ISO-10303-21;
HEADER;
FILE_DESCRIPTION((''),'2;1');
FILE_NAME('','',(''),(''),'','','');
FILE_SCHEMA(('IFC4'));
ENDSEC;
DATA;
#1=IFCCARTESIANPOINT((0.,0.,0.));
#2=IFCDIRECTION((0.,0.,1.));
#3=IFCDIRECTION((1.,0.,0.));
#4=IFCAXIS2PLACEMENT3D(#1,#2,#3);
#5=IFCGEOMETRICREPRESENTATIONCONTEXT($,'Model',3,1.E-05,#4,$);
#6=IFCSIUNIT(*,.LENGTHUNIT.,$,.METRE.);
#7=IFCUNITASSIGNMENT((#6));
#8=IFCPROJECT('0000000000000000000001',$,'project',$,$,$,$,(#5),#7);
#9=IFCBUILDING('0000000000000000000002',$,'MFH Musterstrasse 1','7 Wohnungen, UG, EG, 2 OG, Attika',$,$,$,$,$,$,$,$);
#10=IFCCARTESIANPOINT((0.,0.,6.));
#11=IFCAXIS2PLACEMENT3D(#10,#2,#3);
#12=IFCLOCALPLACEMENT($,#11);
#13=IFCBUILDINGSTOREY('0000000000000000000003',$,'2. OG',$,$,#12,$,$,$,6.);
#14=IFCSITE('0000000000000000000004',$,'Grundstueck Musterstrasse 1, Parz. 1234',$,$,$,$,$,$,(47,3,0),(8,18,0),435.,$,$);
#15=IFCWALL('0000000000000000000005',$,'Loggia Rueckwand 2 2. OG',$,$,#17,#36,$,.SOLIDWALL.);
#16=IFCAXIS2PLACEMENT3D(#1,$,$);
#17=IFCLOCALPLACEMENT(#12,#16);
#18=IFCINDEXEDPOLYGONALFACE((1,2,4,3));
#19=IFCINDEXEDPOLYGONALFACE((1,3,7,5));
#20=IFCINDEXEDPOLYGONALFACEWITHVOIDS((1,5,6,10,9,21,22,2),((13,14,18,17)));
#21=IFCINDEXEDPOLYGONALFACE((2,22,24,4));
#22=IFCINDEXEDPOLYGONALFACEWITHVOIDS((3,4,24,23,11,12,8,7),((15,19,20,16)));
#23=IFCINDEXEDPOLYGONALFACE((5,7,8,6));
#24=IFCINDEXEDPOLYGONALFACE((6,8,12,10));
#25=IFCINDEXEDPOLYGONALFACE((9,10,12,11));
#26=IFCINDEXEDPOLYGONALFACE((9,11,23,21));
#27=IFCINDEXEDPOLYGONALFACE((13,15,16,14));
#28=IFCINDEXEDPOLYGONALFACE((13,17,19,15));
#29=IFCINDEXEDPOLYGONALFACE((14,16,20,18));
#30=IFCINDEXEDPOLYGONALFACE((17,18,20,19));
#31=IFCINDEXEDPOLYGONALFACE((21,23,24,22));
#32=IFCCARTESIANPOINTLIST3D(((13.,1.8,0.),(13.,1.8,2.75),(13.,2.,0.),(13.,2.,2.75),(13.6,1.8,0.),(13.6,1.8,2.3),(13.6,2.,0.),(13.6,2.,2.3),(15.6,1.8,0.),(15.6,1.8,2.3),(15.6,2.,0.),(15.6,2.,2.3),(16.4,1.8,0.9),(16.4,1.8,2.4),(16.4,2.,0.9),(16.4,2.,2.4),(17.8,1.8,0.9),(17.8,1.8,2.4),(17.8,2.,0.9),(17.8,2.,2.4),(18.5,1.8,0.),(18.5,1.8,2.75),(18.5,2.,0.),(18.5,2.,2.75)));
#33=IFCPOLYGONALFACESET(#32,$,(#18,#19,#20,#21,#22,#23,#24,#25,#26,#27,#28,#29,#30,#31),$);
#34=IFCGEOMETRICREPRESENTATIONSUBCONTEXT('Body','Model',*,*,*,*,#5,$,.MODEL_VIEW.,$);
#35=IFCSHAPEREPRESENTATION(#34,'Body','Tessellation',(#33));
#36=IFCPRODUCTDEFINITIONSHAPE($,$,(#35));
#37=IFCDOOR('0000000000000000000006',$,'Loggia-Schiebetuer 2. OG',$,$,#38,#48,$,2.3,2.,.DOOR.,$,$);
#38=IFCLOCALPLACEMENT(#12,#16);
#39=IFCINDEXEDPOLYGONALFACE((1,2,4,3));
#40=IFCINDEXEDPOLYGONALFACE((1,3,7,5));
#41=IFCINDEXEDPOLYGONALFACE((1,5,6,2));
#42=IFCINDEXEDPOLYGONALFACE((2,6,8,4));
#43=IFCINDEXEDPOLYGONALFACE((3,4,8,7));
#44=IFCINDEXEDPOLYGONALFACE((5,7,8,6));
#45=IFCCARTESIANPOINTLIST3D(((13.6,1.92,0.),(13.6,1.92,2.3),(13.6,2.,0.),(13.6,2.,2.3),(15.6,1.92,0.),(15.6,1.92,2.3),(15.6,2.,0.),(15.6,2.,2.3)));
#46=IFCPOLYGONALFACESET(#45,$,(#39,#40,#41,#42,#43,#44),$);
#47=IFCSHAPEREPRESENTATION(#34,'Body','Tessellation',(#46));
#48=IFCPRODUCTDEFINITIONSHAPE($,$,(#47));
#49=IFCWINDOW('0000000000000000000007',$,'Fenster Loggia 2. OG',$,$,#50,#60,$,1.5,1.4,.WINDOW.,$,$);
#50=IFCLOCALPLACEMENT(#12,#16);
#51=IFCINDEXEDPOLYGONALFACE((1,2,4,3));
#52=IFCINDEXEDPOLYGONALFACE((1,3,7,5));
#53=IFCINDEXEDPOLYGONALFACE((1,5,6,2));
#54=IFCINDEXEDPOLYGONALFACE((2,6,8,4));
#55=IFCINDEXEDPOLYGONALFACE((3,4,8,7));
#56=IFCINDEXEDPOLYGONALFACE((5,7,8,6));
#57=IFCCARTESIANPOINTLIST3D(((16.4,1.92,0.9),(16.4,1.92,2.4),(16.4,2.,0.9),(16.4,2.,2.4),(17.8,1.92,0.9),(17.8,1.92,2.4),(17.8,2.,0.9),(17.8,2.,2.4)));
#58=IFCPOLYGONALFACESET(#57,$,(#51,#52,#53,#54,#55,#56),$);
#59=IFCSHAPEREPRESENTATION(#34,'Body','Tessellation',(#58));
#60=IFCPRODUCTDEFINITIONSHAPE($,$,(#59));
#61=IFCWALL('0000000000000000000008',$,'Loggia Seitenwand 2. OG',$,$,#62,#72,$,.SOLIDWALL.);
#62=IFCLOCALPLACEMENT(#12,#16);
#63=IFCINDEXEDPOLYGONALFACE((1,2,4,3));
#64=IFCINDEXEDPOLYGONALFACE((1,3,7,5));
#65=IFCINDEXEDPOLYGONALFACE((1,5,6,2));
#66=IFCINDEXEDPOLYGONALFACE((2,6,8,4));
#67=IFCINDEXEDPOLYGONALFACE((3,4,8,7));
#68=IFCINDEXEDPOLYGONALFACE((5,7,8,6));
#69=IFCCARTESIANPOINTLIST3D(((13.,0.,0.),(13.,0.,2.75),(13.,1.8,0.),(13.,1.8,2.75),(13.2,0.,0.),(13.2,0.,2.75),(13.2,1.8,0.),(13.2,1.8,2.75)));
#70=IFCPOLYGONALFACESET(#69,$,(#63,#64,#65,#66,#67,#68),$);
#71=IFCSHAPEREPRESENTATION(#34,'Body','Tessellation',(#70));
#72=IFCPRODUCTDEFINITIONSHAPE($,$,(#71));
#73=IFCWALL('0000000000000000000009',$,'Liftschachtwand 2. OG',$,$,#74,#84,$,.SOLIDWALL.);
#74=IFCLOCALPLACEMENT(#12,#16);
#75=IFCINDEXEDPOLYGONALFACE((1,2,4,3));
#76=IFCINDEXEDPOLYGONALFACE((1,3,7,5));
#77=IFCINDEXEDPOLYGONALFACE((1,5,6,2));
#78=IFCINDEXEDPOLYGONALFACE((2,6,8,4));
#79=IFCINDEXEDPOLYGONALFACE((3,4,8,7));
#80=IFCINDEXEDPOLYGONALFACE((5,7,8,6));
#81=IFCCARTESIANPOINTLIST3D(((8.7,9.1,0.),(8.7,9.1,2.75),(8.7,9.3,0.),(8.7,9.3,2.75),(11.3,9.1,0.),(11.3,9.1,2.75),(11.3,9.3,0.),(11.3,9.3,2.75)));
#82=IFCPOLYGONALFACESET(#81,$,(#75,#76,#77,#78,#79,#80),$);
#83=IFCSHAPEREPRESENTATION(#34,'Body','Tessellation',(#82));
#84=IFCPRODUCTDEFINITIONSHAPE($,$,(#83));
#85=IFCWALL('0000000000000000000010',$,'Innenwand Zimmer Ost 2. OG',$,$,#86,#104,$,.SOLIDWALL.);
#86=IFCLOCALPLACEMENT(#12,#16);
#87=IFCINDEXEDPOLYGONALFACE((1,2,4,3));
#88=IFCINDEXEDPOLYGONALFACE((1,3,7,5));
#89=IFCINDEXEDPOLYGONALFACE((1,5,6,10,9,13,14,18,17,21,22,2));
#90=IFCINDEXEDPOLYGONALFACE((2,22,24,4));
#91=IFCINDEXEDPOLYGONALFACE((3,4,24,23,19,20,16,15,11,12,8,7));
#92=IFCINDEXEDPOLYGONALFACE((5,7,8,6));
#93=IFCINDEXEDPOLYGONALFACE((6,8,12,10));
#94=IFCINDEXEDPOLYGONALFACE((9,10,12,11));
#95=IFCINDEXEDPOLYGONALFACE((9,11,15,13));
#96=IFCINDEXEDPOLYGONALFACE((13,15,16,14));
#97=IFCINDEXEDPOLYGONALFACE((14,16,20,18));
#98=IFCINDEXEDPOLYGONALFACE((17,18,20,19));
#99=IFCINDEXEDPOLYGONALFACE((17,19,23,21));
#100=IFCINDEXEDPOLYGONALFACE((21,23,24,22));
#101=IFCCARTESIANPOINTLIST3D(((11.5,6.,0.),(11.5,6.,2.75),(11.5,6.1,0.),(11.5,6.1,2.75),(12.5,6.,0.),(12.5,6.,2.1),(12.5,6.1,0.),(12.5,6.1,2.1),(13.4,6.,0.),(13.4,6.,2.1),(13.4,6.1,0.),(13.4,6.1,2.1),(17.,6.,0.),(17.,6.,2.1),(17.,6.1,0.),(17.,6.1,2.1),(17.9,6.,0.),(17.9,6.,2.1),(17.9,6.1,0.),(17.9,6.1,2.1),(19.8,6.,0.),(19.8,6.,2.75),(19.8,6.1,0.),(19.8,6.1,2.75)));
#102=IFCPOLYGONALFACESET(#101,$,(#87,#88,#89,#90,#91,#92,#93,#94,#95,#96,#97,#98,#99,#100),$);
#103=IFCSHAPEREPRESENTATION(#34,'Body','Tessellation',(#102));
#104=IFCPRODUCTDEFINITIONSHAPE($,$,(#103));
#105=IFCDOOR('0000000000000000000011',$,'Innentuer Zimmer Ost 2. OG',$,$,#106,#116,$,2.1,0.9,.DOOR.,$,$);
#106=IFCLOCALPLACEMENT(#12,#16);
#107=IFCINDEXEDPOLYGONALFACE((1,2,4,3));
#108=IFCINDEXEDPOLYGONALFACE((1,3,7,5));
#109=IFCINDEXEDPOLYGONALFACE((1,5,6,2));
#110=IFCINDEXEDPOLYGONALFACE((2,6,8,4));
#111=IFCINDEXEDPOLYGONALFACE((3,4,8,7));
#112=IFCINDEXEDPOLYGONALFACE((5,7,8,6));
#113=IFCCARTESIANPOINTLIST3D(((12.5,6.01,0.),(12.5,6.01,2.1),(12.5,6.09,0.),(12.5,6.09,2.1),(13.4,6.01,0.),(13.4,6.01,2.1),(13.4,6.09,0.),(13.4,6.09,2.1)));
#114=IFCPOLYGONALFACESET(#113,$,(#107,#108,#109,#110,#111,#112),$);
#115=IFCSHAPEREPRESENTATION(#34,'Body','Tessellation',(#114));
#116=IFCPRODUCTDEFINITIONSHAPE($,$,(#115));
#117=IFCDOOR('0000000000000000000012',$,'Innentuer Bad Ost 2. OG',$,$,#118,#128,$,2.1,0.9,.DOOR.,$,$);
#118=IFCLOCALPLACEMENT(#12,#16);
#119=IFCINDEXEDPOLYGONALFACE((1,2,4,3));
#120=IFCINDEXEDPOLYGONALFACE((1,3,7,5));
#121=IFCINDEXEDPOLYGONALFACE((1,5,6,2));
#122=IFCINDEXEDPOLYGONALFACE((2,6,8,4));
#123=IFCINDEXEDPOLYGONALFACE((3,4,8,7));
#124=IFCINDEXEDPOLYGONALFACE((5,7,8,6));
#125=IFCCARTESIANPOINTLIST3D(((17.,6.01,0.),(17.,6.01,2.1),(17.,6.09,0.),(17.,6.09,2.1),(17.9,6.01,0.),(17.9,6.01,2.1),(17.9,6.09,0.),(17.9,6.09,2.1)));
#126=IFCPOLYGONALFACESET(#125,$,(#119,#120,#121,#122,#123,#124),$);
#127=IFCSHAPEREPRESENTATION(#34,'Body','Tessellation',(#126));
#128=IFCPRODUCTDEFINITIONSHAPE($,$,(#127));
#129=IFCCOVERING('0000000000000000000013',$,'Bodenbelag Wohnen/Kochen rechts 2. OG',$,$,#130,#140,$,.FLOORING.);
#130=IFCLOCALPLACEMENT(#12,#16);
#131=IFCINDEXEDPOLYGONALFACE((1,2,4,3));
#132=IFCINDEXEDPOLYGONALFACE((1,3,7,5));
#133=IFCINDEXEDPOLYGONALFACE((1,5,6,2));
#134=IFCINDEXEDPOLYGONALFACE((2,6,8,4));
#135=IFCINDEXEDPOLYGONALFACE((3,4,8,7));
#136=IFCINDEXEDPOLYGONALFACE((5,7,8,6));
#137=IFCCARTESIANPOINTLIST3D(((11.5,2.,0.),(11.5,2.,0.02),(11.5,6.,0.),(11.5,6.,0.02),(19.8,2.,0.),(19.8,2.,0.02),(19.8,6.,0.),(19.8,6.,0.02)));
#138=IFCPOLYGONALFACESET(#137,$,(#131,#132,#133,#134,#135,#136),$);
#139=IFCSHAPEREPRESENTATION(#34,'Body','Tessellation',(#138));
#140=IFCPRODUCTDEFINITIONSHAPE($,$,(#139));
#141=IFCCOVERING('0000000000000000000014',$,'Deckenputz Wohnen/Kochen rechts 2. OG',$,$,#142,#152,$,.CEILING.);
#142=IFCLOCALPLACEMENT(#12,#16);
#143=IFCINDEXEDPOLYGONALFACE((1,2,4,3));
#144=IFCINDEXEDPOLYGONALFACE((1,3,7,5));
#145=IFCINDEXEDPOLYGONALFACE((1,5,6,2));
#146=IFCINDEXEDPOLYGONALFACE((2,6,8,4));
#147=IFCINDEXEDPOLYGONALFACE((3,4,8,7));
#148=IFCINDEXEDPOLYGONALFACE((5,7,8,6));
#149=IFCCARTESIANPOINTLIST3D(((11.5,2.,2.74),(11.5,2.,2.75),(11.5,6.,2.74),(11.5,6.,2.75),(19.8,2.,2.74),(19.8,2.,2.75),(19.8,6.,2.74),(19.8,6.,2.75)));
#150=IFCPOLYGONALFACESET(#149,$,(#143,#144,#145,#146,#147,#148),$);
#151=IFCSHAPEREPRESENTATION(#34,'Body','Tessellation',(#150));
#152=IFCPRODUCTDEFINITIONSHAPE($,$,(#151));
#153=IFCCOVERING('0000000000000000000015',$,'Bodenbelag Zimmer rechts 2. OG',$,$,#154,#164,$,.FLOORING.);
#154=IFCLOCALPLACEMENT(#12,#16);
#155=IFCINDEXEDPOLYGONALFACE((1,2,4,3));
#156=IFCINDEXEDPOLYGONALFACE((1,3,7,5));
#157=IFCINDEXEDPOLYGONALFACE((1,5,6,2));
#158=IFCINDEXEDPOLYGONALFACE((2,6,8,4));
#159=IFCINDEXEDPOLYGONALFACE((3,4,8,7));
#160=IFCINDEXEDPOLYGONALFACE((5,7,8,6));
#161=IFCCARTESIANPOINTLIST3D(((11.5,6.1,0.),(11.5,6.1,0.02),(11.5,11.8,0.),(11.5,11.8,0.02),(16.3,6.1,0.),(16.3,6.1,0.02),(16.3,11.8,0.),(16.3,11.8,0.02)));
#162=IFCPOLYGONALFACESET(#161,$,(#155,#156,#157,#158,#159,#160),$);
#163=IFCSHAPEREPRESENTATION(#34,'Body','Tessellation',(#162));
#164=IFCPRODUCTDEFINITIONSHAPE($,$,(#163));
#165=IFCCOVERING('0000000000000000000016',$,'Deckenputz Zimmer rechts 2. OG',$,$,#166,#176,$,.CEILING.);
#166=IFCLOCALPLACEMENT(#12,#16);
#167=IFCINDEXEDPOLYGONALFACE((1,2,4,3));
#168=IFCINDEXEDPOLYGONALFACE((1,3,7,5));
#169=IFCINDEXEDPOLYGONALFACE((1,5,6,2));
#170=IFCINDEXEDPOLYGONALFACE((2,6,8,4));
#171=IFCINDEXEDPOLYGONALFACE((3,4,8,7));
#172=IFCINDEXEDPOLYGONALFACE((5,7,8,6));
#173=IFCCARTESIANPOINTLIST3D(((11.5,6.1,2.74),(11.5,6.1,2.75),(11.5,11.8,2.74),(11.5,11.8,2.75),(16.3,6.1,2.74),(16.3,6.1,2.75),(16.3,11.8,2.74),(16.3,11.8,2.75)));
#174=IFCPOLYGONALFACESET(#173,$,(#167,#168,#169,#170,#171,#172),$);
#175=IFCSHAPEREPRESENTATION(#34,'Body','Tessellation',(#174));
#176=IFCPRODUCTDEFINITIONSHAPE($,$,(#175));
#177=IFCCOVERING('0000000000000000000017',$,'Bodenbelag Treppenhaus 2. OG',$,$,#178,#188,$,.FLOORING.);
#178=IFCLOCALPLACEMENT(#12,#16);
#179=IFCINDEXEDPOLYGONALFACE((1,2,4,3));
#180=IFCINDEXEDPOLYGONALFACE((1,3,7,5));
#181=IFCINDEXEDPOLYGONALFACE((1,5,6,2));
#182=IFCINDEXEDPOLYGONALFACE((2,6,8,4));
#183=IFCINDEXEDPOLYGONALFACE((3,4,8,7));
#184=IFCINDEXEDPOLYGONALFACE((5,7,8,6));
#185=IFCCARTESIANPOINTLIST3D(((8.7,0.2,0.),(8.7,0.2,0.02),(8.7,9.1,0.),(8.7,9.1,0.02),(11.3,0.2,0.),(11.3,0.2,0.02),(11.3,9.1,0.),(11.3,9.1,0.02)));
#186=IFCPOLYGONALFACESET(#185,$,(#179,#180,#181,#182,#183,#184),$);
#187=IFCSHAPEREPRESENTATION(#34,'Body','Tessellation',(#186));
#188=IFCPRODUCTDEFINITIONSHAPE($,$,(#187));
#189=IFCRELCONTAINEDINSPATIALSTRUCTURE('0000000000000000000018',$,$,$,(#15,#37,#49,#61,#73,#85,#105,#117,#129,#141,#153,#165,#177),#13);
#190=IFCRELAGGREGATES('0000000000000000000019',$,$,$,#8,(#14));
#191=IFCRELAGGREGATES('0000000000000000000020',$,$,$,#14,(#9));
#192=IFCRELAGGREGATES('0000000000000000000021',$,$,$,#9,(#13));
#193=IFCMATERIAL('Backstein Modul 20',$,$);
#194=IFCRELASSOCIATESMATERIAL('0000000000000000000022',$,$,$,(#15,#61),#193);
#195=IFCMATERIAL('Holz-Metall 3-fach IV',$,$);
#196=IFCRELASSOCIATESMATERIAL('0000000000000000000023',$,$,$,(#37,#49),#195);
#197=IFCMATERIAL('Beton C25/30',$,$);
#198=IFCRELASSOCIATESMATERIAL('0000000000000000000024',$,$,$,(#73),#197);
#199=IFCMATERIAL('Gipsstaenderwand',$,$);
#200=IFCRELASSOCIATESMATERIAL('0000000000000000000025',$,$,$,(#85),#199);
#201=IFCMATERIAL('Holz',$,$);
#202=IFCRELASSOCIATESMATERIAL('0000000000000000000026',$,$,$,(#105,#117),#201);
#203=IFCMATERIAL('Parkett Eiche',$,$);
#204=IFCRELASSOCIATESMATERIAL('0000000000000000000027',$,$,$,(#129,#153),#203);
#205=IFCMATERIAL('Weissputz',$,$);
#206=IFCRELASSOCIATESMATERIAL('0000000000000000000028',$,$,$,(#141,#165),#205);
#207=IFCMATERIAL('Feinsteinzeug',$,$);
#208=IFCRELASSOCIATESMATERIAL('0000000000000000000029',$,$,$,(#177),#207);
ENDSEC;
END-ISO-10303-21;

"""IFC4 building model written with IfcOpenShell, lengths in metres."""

from ifc_helpers import new_model, si_unit, frame, frame_2d, origin_with_axes, place, context, subcontext, project, spatial, rectangle, extrude, material, element, fill, save


model = new_model("IFC4")

# Units and contexts
model_context = context("Model", 3, precision=1e-05, world=origin_with_axes())
body_context = subcontext(model_context, "Body", "Model", "MODEL_VIEW")
ifc_project = project(units=[si_unit("LENGTHUNIT", "METRE")], contexts=[model_context])

# Site, building, storey
site = spatial("IfcSite", under=ifc_project, Name="Grundstueck Musterstrasse 1, Parz. 1234", RefLatitude=(47, 3, 0), RefLongitude=(8, 18, 0), RefElevation=435.0)
building = spatial("IfcBuilding", under=site, Name="MFH Musterstrasse 1", Description="7 Wohnungen, UG, EG, 2 OG, Attika")
storey_placement = place(None, frame((0.0, 0.0, 6.0), z_axis=(0.0, 0.0, 1.0), x_axis=(1.0, 0.0, 0.0)))
storey = spatial("IfcBuildingStorey", under=building, at=storey_placement, Name="2. OG", Elevation=6.0)

# Wall, openings, door, window
ifc_material_1 = material(Name="Backstein Modul 20")
wall_1_placement = place(storey_placement, frame((13.0, 1.8, 0.0), z_axis=(0.0, 0.0, 1.0), x_axis=(1.0, 0.0, 0.0)))
wall_1 = element("IfcWall", 1, at=wall_1_placement, inside=storey, material=ifc_material_1, Name="Loggia Rueckwand 2 2. OG", PredefinedType="SOLIDWALL", context=body_context, shape_type="SweptSolid", body=[
    extrude(rectangle(XDim=5.5, YDim=0.2, at=frame_2d((2.75, 0.1))), origin_with_axes(), (0.0, 0.0, 1.0), 2.75),
])
opening_1_placement = place(wall_1_placement, frame((0.6, -0.21, 0.0), z_axis=(0.0, 0.0, 1.0), x_axis=(1.0, 0.0, 0.0)))
opening_1 = element("IfcOpeningElement", 2, at=opening_1_placement, cuts=wall_1, context=body_context, shape_type="SweptSolid", body=[
    extrude(rectangle(XDim=2.0, YDim=0.42, at=frame_2d((1.0, 0.21))), origin_with_axes(), (0.0, 0.0, 1.0), 2.3),
])
opening_2_placement = place(wall_1_placement, frame((3.4, -0.21, 0.9), z_axis=(0.0, 0.0, 1.0), x_axis=(1.0, 0.0, 0.0)))
opening_2 = element("IfcOpeningElement", 3, at=opening_2_placement, cuts=wall_1, context=body_context, shape_type="SweptSolid", body=[
    extrude(rectangle(XDim=1.4, YDim=0.42, at=frame_2d((0.7, 0.21))), origin_with_axes(), (0.0, 0.0, 1.0), 1.5),
])
ifc_material_2 = material(Name="Holz-Metall 3-fach IV")
door_1_placement = place(storey_placement, frame((13.6, 1.92, 0.0), z_axis=(0.0, 0.0, 1.0), x_axis=(1.0, 0.0, 0.0)))
door_1 = element("IfcDoor", 4, at=door_1_placement, inside=storey, material=ifc_material_2, Name="Loggia-Schiebetuer 2. OG", OverallHeight=2.3, OverallWidth=2.0, PredefinedType="DOOR", context=body_context, shape_type="SweptSolid", body=[
    extrude(rectangle(XDim=2.0, YDim=0.08, at=frame_2d((1.0, 0.04))), origin_with_axes(), (0.0, 0.0, 1.0), 2.3),
])
fill(opening_1, door_1)
window_placement = place(storey_placement, frame((16.4, 1.92, 0.9), z_axis=(0.0, 0.0, 1.0), x_axis=(1.0, 0.0, 0.0)))
window = element("IfcWindow", 5, at=window_placement, inside=storey, material=ifc_material_2, Name="Fenster Loggia 2. OG", OverallHeight=1.5, OverallWidth=1.4, PredefinedType="WINDOW", context=body_context, shape_type="SweptSolid", body=[
    extrude(rectangle(XDim=1.4, YDim=0.08, at=frame_2d((0.7, 0.04))), origin_with_axes(), (0.0, 0.0, 1.0), 1.5),
])
fill(opening_2, window)

# Wall
wall_2_placement = place(storey_placement, frame((13.0, 0.2, 0.0), z_axis=(0.0, 0.0, 1.0), x_axis=(1.0, 0.0, 0.0)))
element("IfcWall", 6, at=wall_2_placement, inside=storey, material=ifc_material_1, Name="Loggia Seitenwand 2. OG", PredefinedType="SOLIDWALL", context=body_context, shape_type="SweptSolid", body=[
    extrude(rectangle(XDim=0.2, YDim=1.8, at=frame_2d((0.1, 0.7))), origin_with_axes(), (0.0, 0.0, 1.0), 2.75),
])

# Shared definitions
ifc_material_3 = material(Name="Beton C25/30")
ifc_material_4 = material(Name="Holz")

# Wall
wall_3_placement = place(storey_placement, frame((8.7, 9.1, 0.0), z_axis=(0.0, 0.0, 1.0), x_axis=(1.0, 0.0, 0.0)))
element("IfcWall", 7, at=wall_3_placement, inside=storey, material=ifc_material_3, Name="Liftschachtwand 2. OG", PredefinedType="SOLIDWALL", context=body_context, shape_type="SweptSolid", body=[
    extrude(rectangle(XDim=2.6, YDim=0.2, at=frame_2d((1.3, 0.1))), origin_with_axes(), (0.0, 0.0, 1.0), 2.75),
])

# Wall, openings, doors
ifc_material_5 = material(Name="Gipsstaenderwand")
wall_4_placement = place(storey_placement, frame((11.5, 6.0, 0.0), z_axis=(0.0, 0.0, 1.0), x_axis=(1.0, 0.0, 0.0)))
wall_4 = element("IfcWall", 8, at=wall_4_placement, inside=storey, material=ifc_material_5, Name="Innenwand Zimmer Ost 2. OG", PredefinedType="SOLIDWALL", context=body_context, shape_type="SweptSolid", body=[
    extrude(rectangle(XDim=8.3, YDim=0.1, at=frame_2d((4.15, 0.05))), origin_with_axes(), (0.0, 0.0, 1.0), 2.75),
])
opening_3_placement = place(wall_4_placement, frame((1.0, -0.01, 0.0), z_axis=(0.0, 0.0, 1.0), x_axis=(1.0, 0.0, 0.0)))
opening_3 = element("IfcOpeningElement", 9, at=opening_3_placement, cuts=wall_4, context=body_context, shape_type="SweptSolid", body=[
    extrude(rectangle(XDim=0.9, YDim=0.12, at=frame_2d((0.45, 0.06))), origin_with_axes(), (0.0, 0.0, 1.0), 2.1),
])
opening_4_placement = place(wall_4_placement, frame((5.5, -0.01, 0.0), z_axis=(0.0, 0.0, 1.0), x_axis=(1.0, 0.0, 0.0)))
opening_4 = element("IfcOpeningElement", 10, at=opening_4_placement, cuts=wall_4, context=body_context, shape_type="SweptSolid", body=[
    extrude(rectangle(XDim=0.9, YDim=0.12, at=frame_2d((0.45, 0.06))), origin_with_axes(), (0.0, 0.0, 1.0), 2.1),
])
door_2_placement = place(storey_placement, frame((12.5, 6.01, 0.0), z_axis=(0.0, 0.0, 1.0), x_axis=(1.0, 0.0, 0.0)))
door_2 = element("IfcDoor", 11, at=door_2_placement, inside=storey, material=ifc_material_4, Name="Innentuer Zimmer Ost 2. OG", OverallHeight=2.1, OverallWidth=0.9, PredefinedType="DOOR", context=body_context, shape_type="SweptSolid", body=[
    extrude(rectangle(XDim=0.9, YDim=0.08, at=frame_2d((0.45, 0.04))), origin_with_axes(), (0.0, 0.0, 1.0), 2.1),
])
fill(opening_3, door_2)
door_3_placement = place(storey_placement, frame((17.0, 6.01, 0.0), z_axis=(0.0, 0.0, 1.0), x_axis=(1.0, 0.0, 0.0)))
door_3 = element("IfcDoor", 12, at=door_3_placement, inside=storey, material=ifc_material_4, Name="Innentuer Bad Ost 2. OG", OverallHeight=2.1, OverallWidth=0.9, PredefinedType="DOOR", context=body_context, shape_type="SweptSolid", body=[
    extrude(rectangle(XDim=0.9, YDim=0.08, at=frame_2d((0.45, 0.04))), origin_with_axes(), (0.0, 0.0, 1.0), 2.1),
])
fill(opening_4, door_3)

# Coverings
ifc_material_6 = material(Name="Parkett Eiche")
covering_1_placement = place(storey_placement, frame((11.5, 2.0, 0.0), z_axis=(0.0, 0.0, 1.0), x_axis=(1.0, 0.0, 0.0)))
element("IfcCovering", 13, at=covering_1_placement, inside=storey, material=ifc_material_6, Name="Bodenbelag Wohnen/Kochen rechts 2. OG", PredefinedType="FLOORING", context=body_context, shape_type="SweptSolid", body=[
    extrude(rectangle(XDim=8.3, YDim=4.0, at=frame_2d((4.15, 2.0))), origin_with_axes(), (0.0, 0.0, 1.0), 0.02),
])
ifc_material_7 = material(Name="Weissputz")
covering_2_placement = place(storey_placement, frame((11.5, 2.0, 2.74), z_axis=(0.0, 0.0, 1.0), x_axis=(1.0, 0.0, 0.0)))
element("IfcCovering", 14, at=covering_2_placement, inside=storey, material=ifc_material_7, Name="Deckenputz Wohnen/Kochen rechts 2. OG", PredefinedType="CEILING", context=body_context, shape_type="SweptSolid", body=[
    extrude(rectangle(XDim=8.3, YDim=4.0, at=frame_2d((4.15, 2.0))), origin_with_axes(), (0.0, 0.0, 1.0), 0.01),
])
covering_3_placement = place(storey_placement, frame((11.5, 6.1, 0.0), z_axis=(0.0, 0.0, 1.0), x_axis=(1.0, 0.0, 0.0)))
element("IfcCovering", 15, at=covering_3_placement, inside=storey, material=ifc_material_6, Name="Bodenbelag Zimmer rechts 2. OG", PredefinedType="FLOORING", context=body_context, shape_type="SweptSolid", body=[
    extrude(rectangle(XDim=4.8, YDim=5.7, at=frame_2d((2.4, 2.85))), origin_with_axes(), (0.0, 0.0, 1.0), 0.02),
])
covering_4_placement = place(storey_placement, frame((11.5, 6.1, 2.74), z_axis=(0.0, 0.0, 1.0), x_axis=(1.0, 0.0, 0.0)))
element("IfcCovering", 16, at=covering_4_placement, inside=storey, material=ifc_material_7, Name="Deckenputz Zimmer rechts 2. OG", PredefinedType="CEILING", context=body_context, shape_type="SweptSolid", body=[
    extrude(rectangle(XDim=4.8, YDim=5.7, at=frame_2d((2.4, 2.85))), origin_with_axes(), (0.0, 0.0, 1.0), 0.01),
])
ifc_material_8 = material(Name="Feinsteinzeug")
covering_5_placement = place(storey_placement, frame((8.7, 0.2, 0.0), z_axis=(0.0, 0.0, 1.0), x_axis=(1.0, 0.0, 0.0)))
element("IfcCovering", 17, at=covering_5_placement, inside=storey, material=ifc_material_8, Name="Bodenbelag Treppenhaus 2. OG", PredefinedType="FLOORING", context=body_context, shape_type="SweptSolid", body=[
    extrude(rectangle(XDim=2.6, YDim=8.9, at=frame_2d((1.3, 4.45))), origin_with_axes(), (0.0, 0.0, 1.0), 0.02),
])

save(model, "model.ifc")
